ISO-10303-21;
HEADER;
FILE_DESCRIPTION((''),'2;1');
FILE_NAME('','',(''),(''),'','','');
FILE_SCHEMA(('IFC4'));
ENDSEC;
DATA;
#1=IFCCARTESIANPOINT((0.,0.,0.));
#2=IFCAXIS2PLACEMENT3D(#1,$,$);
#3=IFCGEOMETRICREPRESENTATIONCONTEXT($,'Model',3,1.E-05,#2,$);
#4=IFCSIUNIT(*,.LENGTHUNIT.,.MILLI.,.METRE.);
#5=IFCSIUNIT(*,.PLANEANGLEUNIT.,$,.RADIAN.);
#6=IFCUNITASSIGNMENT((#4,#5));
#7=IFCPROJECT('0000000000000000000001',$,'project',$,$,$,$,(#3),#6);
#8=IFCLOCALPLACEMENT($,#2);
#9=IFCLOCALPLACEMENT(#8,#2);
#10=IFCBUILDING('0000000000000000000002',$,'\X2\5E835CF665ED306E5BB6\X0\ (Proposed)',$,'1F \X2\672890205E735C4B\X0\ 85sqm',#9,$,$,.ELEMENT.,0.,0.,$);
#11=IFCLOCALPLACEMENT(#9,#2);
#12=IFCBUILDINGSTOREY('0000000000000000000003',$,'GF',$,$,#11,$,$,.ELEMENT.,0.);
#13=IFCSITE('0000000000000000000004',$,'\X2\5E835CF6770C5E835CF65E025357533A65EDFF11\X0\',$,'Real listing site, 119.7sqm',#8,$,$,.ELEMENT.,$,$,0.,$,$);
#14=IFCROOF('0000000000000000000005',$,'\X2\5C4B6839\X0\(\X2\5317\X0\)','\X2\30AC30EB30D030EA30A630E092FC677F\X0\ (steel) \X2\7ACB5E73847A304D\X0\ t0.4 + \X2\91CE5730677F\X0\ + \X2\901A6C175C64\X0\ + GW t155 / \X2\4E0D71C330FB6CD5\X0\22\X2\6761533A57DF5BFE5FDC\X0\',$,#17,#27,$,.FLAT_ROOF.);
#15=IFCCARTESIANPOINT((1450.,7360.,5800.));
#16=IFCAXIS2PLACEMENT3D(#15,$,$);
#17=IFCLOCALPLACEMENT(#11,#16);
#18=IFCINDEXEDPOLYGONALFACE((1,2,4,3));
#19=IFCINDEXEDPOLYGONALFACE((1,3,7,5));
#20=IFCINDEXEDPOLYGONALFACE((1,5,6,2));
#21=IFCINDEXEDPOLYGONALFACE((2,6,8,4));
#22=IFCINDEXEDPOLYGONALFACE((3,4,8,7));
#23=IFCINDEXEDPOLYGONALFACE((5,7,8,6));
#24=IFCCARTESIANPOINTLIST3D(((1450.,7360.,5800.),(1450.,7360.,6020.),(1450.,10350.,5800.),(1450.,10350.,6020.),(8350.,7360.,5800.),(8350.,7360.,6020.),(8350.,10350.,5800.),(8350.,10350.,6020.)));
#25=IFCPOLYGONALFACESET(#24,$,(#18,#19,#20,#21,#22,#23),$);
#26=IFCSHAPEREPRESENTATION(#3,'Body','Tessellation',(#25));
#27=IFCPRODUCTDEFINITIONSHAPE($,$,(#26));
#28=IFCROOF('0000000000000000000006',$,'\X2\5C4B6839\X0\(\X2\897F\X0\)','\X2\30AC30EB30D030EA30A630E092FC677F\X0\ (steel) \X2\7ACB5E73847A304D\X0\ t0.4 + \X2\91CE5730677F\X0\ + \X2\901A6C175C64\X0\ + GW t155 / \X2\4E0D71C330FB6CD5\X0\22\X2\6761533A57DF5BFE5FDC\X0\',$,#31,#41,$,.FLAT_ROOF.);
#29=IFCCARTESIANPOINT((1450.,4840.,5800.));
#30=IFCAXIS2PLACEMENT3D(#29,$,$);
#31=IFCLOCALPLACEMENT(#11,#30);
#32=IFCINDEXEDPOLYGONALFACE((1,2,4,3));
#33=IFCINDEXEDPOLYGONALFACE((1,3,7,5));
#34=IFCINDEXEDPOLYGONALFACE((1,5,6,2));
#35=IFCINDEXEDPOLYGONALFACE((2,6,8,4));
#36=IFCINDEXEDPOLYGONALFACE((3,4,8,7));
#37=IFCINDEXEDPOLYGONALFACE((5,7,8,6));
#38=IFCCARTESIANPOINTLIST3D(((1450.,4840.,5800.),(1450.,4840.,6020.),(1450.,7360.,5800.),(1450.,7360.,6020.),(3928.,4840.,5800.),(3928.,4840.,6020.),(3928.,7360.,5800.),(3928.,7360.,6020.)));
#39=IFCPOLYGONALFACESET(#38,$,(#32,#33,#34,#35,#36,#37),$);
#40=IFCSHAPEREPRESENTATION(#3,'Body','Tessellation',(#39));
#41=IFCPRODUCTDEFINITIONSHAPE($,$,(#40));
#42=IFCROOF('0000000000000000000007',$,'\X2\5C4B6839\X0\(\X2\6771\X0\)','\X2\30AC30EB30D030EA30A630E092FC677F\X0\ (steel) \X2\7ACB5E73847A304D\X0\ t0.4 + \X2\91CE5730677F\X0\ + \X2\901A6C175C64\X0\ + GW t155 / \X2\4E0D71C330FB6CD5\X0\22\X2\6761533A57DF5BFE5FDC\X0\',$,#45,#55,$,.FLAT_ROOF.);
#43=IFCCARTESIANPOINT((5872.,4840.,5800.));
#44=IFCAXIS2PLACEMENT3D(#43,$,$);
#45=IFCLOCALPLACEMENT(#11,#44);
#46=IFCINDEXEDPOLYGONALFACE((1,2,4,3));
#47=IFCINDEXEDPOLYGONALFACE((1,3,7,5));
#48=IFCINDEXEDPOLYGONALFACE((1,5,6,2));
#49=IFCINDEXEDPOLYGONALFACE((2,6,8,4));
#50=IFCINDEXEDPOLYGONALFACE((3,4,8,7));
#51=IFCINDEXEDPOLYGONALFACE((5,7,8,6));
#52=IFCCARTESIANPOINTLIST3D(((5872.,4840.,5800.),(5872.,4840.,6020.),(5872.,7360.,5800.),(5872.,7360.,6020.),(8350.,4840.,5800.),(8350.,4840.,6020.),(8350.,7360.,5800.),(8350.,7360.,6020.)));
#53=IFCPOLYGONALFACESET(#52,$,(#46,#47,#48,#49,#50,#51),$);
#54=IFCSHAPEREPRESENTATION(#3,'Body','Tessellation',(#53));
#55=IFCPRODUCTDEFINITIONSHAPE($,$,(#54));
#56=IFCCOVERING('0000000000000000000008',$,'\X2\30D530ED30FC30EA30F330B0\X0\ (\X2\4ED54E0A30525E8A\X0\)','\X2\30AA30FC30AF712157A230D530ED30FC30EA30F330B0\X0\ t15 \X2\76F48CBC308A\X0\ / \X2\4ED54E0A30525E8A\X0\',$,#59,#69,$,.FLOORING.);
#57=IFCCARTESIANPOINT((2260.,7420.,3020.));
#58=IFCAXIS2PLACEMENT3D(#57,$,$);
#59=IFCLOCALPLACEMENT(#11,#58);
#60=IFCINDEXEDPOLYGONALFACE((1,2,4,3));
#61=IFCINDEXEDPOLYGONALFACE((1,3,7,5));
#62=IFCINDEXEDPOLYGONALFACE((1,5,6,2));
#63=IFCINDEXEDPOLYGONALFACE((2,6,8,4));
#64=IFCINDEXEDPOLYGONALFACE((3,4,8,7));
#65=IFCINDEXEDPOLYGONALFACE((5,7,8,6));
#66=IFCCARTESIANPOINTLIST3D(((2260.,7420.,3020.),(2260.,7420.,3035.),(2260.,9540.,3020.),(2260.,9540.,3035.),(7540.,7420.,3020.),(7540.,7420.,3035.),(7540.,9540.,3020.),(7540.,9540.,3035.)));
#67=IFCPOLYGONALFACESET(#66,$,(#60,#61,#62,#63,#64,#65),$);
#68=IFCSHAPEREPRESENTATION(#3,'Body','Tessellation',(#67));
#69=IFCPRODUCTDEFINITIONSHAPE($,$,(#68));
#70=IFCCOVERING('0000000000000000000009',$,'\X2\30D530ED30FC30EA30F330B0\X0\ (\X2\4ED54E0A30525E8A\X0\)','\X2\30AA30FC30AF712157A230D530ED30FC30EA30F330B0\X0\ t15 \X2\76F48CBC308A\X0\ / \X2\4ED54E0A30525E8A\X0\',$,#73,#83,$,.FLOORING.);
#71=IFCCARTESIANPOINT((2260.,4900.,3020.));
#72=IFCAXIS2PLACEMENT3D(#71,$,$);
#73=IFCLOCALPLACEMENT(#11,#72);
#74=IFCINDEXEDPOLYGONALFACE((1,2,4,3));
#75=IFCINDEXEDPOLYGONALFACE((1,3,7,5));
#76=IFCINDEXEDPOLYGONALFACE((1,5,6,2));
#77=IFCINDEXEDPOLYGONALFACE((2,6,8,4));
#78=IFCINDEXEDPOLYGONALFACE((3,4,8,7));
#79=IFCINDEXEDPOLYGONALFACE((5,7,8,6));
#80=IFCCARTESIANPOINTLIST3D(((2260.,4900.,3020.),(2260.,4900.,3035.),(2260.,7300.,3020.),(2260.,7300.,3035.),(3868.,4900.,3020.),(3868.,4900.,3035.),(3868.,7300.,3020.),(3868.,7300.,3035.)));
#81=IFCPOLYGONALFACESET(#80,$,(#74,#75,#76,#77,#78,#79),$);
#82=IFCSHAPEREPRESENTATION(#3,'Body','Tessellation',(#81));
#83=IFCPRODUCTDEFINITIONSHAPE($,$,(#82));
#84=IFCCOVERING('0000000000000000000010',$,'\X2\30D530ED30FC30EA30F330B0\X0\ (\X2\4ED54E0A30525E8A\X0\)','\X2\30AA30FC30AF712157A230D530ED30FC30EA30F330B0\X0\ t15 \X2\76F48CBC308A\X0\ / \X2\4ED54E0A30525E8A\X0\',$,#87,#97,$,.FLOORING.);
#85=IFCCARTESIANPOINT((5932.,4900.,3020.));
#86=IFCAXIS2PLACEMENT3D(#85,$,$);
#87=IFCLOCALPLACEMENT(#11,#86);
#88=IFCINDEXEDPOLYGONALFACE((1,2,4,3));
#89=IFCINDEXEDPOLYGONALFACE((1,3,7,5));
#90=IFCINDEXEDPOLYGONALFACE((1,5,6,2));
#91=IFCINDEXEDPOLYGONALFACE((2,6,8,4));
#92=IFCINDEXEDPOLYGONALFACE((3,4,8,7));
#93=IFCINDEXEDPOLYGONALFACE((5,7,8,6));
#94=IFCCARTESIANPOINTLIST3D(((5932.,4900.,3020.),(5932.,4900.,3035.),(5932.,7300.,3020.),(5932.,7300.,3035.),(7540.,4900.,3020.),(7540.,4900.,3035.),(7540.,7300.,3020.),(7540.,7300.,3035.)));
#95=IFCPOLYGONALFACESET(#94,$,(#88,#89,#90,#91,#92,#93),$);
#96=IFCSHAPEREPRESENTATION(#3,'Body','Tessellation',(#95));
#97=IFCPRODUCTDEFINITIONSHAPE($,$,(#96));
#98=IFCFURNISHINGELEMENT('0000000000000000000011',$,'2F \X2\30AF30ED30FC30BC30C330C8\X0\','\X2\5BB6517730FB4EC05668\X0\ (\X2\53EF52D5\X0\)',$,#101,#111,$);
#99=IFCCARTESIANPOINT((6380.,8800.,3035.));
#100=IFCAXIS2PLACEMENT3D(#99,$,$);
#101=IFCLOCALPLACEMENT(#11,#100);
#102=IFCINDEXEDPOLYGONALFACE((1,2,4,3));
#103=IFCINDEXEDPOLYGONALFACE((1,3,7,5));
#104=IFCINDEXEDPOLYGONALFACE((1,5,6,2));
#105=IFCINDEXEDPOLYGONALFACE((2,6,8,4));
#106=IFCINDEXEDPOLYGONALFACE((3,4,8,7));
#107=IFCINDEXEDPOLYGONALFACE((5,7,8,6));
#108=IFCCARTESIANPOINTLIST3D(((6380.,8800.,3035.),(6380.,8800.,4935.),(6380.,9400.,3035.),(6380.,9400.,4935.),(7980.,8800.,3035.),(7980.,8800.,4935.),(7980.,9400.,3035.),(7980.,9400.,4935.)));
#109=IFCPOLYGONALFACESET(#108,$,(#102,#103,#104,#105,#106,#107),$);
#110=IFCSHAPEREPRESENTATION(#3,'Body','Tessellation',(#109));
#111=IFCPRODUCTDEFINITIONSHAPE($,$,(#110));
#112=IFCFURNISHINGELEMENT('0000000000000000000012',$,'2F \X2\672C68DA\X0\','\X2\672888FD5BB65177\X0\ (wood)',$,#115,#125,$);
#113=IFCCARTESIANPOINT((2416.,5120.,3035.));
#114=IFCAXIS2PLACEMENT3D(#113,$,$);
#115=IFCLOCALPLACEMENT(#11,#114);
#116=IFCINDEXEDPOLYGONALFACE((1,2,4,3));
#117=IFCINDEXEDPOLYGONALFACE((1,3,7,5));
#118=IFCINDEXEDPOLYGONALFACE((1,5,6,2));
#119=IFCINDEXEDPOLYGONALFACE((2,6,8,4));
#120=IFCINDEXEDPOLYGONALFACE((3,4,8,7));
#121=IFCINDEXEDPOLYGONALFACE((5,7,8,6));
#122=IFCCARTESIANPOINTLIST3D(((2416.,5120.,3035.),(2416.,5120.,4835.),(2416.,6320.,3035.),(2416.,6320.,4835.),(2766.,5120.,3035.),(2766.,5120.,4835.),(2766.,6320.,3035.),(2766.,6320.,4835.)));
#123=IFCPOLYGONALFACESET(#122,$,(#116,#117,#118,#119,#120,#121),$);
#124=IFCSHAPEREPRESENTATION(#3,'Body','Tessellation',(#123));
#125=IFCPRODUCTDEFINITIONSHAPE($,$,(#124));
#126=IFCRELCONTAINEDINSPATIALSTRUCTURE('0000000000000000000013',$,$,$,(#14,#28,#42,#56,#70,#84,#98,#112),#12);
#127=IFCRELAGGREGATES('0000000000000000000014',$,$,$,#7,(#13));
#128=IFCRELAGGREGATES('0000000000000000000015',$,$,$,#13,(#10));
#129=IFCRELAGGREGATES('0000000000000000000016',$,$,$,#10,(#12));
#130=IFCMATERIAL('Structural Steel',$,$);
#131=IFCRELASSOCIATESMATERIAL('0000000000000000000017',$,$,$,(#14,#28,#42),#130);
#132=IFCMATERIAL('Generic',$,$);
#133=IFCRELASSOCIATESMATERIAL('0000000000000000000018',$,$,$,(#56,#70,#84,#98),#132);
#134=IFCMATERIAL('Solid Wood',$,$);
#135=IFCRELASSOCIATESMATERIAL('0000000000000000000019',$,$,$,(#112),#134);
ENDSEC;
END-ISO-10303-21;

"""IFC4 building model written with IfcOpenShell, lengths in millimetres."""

from ifc_helpers import new_model, si_unit, frame, frame_2d, origin, place, context, project, spatial, rectangle, extrude, material, element, save


model = new_model("IFC4")

# Units and contexts
model_context = context("Model", 3, precision=1e-05, world=origin())
ifc_project = project(units=[si_unit("LENGTHUNIT", "METRE", prefix="MILLI"), si_unit("PLANEANGLEUNIT", "RADIAN")], contexts=[model_context])

# Site, building, storey
site_placement = place(None, origin())
site = spatial("IfcSite", under=ifc_project, at=site_placement, Name="広島県広島市南区旭１", ObjectType="Real listing site, 119.7sqm", CompositionType="ELEMENT", RefElevation=0.0)
building_placement = place(site_placement, origin())
building = spatial("IfcBuilding", under=site, at=building_placement, Name="広島旭の家 (Proposed)", ObjectType="1F 木造平屋 85sqm", CompositionType="ELEMENT", ElevationOfRefHeight=0.0, ElevationOfTerrain=0.0)
storey_placement = place(building_placement, origin())
storey = spatial("IfcBuildingStorey", under=building, at=storey_placement, Name="GF", CompositionType="ELEMENT", Elevation=0.0)

# Shared definitions
ifc_material_1 = material(Name="Solid Wood")

# Shared definitions
ifc_material_2 = material(Name="Generic")

# Roofs
ifc_material_3 = material(Name="Structural Steel")
for number, where, name in (
    (1, (1450.0, 7360.0, 5800.0), "屋根(北)"),
):
    element("IfcRoof", number, at=place(storey_placement, frame(where)), inside=storey, material=ifc_material_3, Name=name, Description="ガルバリウム鋼板 (steel) 立平葺き t0.4 + 野地板 + 通気層 + GW t155 / 不燃・法22条区域対応", PredefinedType="FLAT_ROOF", context=model_context, shape_type="SweptSolid", body=[
        extrude(rectangle(XDim=6900.0, YDim=2990.0, at=frame_2d((3450.0, 1495.0))), frame((1450.0, 7360.0, 5800.0)), (0.0, 0.0, 1.0), 220.0),
    ])
roof_1_placement = place(storey_placement, frame((1450.0, 4840.0, 5800.0)))
element("IfcRoof", 2, at=roof_1_placement, inside=storey, material=ifc_material_3, Name="屋根(西)", Description="ガルバリウム鋼板 (steel) 立平葺き t0.4 + 野地板 + 通気層 + GW t155 / 不燃・法22条区域対応", PredefinedType="FLAT_ROOF", context=model_context, shape_type="SweptSolid", body=[
    extrude(rectangle(XDim=2478.0, YDim=2520.0, at=frame_2d((1239.0, 1260.0))), frame((1450.0, 4840.0, 5800.0)), (0.0, 0.0, 1.0), 220.0),
])
roof_2_placement = place(storey_placement, frame((5872.0, 4840.0, 5800.0)))
element("IfcRoof", 3, at=roof_2_placement, inside=storey, material=ifc_material_3, Name="屋根(東)", Description="ガルバリウム鋼板 (steel) 立平葺き t0.4 + 野地板 + 通気層 + GW t155 / 不燃・法22条区域対応", PredefinedType="FLAT_ROOF", context=model_context, shape_type="SweptSolid", body=[
    extrude(rectangle(XDim=2478.0, YDim=2520.0, at=frame_2d((1239.0, 1260.0))), frame((5872.0, 4840.0, 5800.0)), (0.0, 0.0, 1.0), 220.0),
])

# Coverings
covering_1_placement = place(storey_placement, frame((2260.0, 7420.0, 3020.0)))
element("IfcCovering", 4, at=covering_1_placement, inside=storey, material=ifc_material_2, Name="フローリング (仕上げ床)", Description="オーク無垢フローリング t15 直貼り / 仕上げ床", PredefinedType="FLOORING", context=model_context, shape_type="SweptSolid", body=[
    extrude(rectangle(XDim=5280.0, YDim=2120.0, at=frame_2d((2640.0, 1060.0))), frame((2260.0, 7420.0, 3020.0)), (0.0, 0.0, 1.0), 15.0),
])
covering_2_placement = place(storey_placement, frame((2260.0, 4900.0, 3020.0)))
element("IfcCovering", 5, at=covering_2_placement, inside=storey, material=ifc_material_2, Name="フローリング (仕上げ床)", Description="オーク無垢フローリング t15 直貼り / 仕上げ床", PredefinedType="FLOORING", context=model_context, shape_type="SweptSolid", body=[
    extrude(rectangle(XDim=1608.0, YDim=2400.0, at=frame_2d((804.0, 1200.0))), frame((2260.0, 4900.0, 3020.0)), (0.0, 0.0, 1.0), 15.0),
])
covering_3_placement = place(storey_placement, frame((5932.0, 4900.0, 3020.0)))
element("IfcCovering", 6, at=covering_3_placement, inside=storey, material=ifc_material_2, Name="フローリング (仕上げ床)", Description="オーク無垢フローリング t15 直貼り / 仕上げ床", PredefinedType="FLOORING", context=model_context, shape_type="SweptSolid", body=[
    extrude(rectangle(XDim=1608.0, YDim=2400.0, at=frame_2d((804.0, 1200.0))), frame((5932.0, 4900.0, 3020.0)), (0.0, 0.0, 1.0), 15.0),
])

# Furnishing elements
furnishing_1_placement = place(storey_placement, frame((6380.0, 8800.0, 3035.0)))
element("IfcFurnishingElement", 7, at=furnishing_1_placement, inside=storey, material=ifc_material_2, Name="2F クローゼット", Description="家具・什器 (可動)", context=model_context, shape_type="SweptSolid", body=[
    extrude(rectangle(XDim=1600.0, YDim=600.0, at=frame_2d((800.0, 300.0))), frame((6380.0, 8800.0, 3035.0)), (0.0, 0.0, 1.0), 1900.0),
])
furnishing_2_placement = place(storey_placement, frame((2416.0, 5120.0, 3035.0)))
element("IfcFurnishingElement", 8, at=furnishing_2_placement, inside=storey, material=ifc_material_1, Name="2F 本棚", Description="木製家具 (wood)", context=model_context, shape_type="SweptSolid", body=[
    extrude(rectangle(XDim=350.0, YDim=1200.0, at=frame_2d((175.0, 600.0))), frame((2416.0, 5120.0, 3035.0)), (0.0, 0.0, 1.0), 1800.0),
])

save(model, "model.ifc")
